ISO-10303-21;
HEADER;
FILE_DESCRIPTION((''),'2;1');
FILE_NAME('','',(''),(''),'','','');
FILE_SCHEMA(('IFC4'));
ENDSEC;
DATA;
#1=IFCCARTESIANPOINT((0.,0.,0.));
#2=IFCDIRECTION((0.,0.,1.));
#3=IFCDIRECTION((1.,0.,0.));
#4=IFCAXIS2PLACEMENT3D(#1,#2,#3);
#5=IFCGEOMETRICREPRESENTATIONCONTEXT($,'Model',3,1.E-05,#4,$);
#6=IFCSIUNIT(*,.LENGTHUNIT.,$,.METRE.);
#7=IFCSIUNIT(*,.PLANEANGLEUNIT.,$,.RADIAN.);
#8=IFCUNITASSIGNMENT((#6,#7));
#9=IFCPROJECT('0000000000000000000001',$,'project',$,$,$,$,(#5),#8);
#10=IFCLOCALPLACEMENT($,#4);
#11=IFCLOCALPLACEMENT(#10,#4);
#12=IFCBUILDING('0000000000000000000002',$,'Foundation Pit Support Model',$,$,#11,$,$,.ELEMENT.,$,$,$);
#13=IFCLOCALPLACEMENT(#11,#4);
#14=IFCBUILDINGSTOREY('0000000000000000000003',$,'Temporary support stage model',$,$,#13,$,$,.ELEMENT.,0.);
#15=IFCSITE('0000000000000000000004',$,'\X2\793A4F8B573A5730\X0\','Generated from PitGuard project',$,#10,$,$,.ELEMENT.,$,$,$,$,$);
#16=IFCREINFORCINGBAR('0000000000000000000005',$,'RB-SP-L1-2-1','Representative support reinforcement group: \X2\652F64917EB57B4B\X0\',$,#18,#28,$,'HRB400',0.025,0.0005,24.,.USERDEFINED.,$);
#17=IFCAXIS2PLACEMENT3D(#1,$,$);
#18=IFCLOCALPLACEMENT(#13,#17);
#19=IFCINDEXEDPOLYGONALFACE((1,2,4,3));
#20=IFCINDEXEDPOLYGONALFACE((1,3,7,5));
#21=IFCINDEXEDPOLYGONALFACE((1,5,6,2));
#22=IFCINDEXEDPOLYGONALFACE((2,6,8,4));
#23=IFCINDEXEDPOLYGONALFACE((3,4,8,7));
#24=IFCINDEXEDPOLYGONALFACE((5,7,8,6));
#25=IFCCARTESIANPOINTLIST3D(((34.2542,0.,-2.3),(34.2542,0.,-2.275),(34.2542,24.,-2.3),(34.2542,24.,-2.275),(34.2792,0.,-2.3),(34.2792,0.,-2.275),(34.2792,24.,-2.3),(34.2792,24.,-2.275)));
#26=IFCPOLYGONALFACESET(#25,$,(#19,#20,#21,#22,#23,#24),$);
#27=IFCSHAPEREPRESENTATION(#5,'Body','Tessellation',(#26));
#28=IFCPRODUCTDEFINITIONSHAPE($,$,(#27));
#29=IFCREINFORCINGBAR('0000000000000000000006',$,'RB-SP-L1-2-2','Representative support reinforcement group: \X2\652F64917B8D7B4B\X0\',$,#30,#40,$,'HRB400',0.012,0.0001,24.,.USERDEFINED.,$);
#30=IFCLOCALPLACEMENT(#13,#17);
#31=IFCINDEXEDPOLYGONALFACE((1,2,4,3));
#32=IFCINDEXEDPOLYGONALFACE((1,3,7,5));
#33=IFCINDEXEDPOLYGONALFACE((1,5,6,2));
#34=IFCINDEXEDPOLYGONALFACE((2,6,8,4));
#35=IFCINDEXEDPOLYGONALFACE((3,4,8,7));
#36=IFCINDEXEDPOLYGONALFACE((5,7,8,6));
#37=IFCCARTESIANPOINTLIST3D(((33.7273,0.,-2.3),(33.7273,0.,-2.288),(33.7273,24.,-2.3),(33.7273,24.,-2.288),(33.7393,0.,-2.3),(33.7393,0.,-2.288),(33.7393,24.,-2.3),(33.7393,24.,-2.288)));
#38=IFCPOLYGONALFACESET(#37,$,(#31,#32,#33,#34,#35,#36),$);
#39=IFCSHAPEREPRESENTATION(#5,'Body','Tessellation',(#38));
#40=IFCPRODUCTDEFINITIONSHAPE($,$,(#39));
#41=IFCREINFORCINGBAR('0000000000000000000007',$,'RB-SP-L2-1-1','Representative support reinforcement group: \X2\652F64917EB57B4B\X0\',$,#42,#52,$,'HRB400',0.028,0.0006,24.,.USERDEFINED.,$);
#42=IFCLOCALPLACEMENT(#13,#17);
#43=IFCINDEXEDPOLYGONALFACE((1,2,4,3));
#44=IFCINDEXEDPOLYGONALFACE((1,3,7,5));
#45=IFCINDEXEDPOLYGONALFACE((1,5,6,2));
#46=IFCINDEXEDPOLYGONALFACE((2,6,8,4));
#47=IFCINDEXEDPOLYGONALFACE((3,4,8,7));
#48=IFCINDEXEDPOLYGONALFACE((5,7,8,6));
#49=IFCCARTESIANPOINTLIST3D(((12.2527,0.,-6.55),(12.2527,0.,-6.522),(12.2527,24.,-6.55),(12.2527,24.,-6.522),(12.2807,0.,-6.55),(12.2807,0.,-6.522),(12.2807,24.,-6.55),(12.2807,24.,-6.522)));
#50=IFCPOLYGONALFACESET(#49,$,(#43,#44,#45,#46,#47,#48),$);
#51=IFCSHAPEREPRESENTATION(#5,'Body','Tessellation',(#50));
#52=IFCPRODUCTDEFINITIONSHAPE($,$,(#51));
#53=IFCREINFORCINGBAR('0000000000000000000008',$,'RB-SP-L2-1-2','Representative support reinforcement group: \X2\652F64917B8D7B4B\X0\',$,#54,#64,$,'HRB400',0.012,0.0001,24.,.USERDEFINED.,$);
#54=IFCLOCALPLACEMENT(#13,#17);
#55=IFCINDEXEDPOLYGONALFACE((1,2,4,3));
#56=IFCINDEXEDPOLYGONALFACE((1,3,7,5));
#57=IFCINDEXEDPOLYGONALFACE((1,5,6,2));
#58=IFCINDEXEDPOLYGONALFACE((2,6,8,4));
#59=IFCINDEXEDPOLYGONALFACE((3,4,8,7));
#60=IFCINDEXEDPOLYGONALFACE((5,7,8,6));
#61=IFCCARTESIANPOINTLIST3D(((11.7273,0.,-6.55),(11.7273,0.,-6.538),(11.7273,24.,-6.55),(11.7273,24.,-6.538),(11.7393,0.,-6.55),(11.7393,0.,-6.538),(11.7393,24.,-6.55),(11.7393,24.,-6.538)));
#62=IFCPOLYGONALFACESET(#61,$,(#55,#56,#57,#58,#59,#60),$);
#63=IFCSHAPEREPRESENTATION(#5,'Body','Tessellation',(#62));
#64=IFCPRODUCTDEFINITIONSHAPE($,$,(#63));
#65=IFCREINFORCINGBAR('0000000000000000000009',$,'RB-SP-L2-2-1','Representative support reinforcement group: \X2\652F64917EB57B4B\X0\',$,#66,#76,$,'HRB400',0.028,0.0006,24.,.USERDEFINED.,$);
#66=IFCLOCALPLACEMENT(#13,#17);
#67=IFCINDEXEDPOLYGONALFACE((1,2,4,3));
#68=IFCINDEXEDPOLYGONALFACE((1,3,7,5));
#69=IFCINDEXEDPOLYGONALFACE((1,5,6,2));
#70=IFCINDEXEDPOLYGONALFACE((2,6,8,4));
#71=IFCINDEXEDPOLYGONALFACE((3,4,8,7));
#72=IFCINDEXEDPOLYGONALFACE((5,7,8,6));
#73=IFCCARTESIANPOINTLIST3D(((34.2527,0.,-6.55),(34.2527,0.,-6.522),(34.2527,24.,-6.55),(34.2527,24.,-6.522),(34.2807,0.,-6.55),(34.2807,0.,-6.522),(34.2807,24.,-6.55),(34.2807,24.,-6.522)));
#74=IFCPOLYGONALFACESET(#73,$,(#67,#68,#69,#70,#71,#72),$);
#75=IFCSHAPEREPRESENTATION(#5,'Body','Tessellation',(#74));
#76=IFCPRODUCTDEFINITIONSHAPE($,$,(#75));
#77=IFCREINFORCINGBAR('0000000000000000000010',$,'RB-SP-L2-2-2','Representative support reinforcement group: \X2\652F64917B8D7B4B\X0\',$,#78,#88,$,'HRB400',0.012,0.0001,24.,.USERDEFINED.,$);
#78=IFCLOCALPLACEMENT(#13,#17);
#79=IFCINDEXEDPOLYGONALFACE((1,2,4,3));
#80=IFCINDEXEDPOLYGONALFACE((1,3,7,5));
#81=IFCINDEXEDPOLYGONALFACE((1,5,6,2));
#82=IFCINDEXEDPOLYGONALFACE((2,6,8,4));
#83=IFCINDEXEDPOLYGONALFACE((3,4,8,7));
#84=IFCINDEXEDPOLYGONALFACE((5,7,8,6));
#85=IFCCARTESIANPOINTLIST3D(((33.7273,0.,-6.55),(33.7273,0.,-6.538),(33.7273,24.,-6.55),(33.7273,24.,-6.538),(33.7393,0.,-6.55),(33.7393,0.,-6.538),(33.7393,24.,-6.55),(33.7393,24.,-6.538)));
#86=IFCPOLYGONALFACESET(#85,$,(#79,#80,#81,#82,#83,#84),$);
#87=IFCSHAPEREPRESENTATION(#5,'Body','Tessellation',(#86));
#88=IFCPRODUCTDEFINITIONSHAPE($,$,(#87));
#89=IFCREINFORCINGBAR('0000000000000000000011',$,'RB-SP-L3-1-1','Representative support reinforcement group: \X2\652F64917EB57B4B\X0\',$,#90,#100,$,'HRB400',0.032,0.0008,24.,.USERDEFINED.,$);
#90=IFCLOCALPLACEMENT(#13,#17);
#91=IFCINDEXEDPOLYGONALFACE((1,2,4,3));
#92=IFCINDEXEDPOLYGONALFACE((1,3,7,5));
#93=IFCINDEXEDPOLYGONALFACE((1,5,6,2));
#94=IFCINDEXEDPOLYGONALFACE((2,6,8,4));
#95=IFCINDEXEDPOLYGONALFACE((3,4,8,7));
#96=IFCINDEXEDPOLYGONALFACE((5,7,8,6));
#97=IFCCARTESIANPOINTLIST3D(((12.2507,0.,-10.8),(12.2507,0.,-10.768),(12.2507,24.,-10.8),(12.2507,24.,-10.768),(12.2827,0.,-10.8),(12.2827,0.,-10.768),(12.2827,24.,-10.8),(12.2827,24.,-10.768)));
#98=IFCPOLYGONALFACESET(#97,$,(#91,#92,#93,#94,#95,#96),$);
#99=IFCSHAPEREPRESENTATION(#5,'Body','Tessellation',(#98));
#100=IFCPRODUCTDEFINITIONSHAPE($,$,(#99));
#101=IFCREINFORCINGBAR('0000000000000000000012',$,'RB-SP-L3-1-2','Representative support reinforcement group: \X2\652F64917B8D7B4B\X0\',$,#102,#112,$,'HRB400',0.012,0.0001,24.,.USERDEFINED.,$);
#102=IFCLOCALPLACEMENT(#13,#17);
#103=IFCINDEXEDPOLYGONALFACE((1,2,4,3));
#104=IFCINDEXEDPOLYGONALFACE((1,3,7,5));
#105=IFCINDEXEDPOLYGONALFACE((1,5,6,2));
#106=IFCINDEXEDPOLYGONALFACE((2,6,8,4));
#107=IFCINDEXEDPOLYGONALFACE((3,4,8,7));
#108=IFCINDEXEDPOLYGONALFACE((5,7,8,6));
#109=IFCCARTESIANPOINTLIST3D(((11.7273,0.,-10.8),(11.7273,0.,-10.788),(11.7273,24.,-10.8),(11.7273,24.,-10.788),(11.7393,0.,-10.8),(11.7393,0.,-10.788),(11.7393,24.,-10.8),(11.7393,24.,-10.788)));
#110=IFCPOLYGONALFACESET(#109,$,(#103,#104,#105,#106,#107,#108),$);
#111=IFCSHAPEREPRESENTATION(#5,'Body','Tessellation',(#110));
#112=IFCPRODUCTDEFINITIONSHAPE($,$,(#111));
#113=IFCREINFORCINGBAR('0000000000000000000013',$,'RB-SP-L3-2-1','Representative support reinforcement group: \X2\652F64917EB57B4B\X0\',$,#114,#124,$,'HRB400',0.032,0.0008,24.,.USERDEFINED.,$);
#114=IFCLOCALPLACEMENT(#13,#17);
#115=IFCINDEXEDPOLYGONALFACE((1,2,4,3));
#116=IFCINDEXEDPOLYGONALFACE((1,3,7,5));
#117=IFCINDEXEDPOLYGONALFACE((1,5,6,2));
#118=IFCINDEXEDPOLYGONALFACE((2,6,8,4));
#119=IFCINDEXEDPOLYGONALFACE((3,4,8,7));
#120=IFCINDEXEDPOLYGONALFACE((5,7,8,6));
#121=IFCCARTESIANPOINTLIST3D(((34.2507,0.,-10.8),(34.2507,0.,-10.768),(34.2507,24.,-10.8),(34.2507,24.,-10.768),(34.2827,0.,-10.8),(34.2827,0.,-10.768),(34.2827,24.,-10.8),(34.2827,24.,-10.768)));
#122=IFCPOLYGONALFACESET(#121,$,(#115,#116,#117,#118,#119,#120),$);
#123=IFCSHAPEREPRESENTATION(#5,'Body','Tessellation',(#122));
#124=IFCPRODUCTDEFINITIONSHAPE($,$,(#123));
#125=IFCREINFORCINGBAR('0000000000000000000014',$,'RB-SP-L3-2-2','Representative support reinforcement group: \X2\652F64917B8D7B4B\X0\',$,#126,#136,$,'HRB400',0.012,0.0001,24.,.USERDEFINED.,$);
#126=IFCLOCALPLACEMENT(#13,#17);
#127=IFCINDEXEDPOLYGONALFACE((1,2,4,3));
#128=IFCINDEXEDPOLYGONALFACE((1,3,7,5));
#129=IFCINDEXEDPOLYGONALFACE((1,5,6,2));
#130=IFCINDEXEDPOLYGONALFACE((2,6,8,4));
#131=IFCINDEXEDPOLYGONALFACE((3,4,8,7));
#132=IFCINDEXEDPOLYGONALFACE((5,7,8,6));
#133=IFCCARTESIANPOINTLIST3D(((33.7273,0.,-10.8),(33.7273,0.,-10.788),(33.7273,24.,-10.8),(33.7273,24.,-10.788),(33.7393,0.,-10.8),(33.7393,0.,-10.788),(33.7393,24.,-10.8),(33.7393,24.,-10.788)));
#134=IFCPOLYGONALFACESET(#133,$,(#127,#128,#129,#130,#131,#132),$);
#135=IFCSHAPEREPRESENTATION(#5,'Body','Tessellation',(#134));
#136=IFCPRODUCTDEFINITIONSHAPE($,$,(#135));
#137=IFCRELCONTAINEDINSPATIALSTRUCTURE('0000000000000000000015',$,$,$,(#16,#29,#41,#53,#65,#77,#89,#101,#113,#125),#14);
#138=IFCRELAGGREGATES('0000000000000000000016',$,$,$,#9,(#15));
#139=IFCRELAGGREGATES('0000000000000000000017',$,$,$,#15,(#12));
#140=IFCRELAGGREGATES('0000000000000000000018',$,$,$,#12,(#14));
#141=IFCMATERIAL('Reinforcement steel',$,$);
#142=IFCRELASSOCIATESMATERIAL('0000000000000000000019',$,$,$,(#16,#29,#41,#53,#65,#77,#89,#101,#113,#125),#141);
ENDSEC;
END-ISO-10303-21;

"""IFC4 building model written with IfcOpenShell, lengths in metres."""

from ifc_helpers import new_model, si_unit, frame, origin_with_axes, origin_2d, place, context, project, spatial, rectangle, extrude, material, element, save


model = new_model("IFC4")

# Units and contexts
model_context = context("Model", 3, precision=1e-05, world=origin_with_axes())
ifc_project = project(units=[si_unit("LENGTHUNIT", "METRE"), si_unit("PLANEANGLEUNIT", "RADIAN")], contexts=[model_context])

# Site, building, storey
site_placement = place(None, origin_with_axes())
site = spatial("IfcSite", under=ifc_project, at=site_placement, Name="示例场地", Description="Generated from PitGuard project", CompositionType="ELEMENT")
building_placement = place(site_placement, origin_with_axes())
building = spatial("IfcBuilding", under=site, at=building_placement, Name="Foundation Pit Support Model", CompositionType="ELEMENT")
storey_placement = place(building_placement, origin_with_axes())
storey = spatial("IfcBuildingStorey", under=building, at=storey_placement, Name="Temporary support stage model", CompositionType="ELEMENT", Elevation=0.0)

# Reinforcing bars
ifc_material_1 = material(Name="Reinforcement steel")
reinforcing_bar_1_placement = place(storey_placement, frame((34.2667, 12.0, -2.3), z_axis=(0.0, 0.0, 1.0), x_axis=(0.0, 1.0, 0.0)))
element("IfcReinforcingBar", 1, at=reinforcing_bar_1_placement, inside=storey, material=ifc_material_1, Name="RB-SP-L1-2-1", Description="Representative support reinforcement group: 支撑纵筋", SteelGrade="HRB400", BarLength=24.0, CrossSectionArea=0.0005, NominalDiameter=0.025, PredefinedType="USERDEFINED", context=model_context, shape_type="SweptSolid", body=[
    extrude(rectangle(XDim=24.0, YDim=0.025, at=origin_2d()), origin_with_axes(), (0.0, 0.0, 1.0), 0.025),
])
reinforcing_bar_2_placement = place(storey_placement, frame((33.7333, 12.0, -2.3), z_axis=(0.0, 0.0, 1.0), x_axis=(0.0, 1.0, 0.0)))
element("IfcReinforcingBar", 2, at=reinforcing_bar_2_placement, inside=storey, material=ifc_material_1, Name="RB-SP-L1-2-2", Description="Representative support reinforcement group: 支撑箍筋", SteelGrade="HRB400", BarLength=24.0, CrossSectionArea=0.0001, NominalDiameter=0.012, PredefinedType="USERDEFINED", context=model_context, shape_type="SweptSolid", body=[
    extrude(rectangle(XDim=24.0, YDim=0.012, at=origin_2d()), origin_with_axes(), (0.0, 0.0, 1.0), 0.012),
])
reinforcing_bar_3_placement = place(storey_placement, frame((12.2667, 12.0, -6.55), z_axis=(0.0, 0.0, 1.0), x_axis=(0.0, 1.0, 0.0)))
element("IfcReinforcingBar", 3, at=reinforcing_bar_3_placement, inside=storey, material=ifc_material_1, Name="RB-SP-L2-1-1", Description="Representative support reinforcement group: 支撑纵筋", SteelGrade="HRB400", BarLength=24.0, CrossSectionArea=0.0006, NominalDiameter=0.028, PredefinedType="USERDEFINED", context=model_context, shape_type="SweptSolid", body=[
    extrude(rectangle(XDim=24.0, YDim=0.028, at=origin_2d()), origin_with_axes(), (0.0, 0.0, 1.0), 0.028),
])
reinforcing_bar_4_placement = place(storey_placement, frame((11.7333, 12.0, -6.55), z_axis=(0.0, 0.0, 1.0), x_axis=(0.0, 1.0, 0.0)))
element("IfcReinforcingBar", 4, at=reinforcing_bar_4_placement, inside=storey, material=ifc_material_1, Name="RB-SP-L2-1-2", Description="Representative support reinforcement group: 支撑箍筋", SteelGrade="HRB400", BarLength=24.0, CrossSectionArea=0.0001, NominalDiameter=0.012, PredefinedType="USERDEFINED", context=model_context, shape_type="SweptSolid", body=[
    extrude(rectangle(XDim=24.0, YDim=0.012, at=origin_2d()), origin_with_axes(), (0.0, 0.0, 1.0), 0.012),
])
reinforcing_bar_5_placement = place(storey_placement, frame((34.2667, 12.0, -6.55), z_axis=(0.0, 0.0, 1.0), x_axis=(0.0, 1.0, 0.0)))
element("IfcReinforcingBar", 5, at=reinforcing_bar_5_placement, inside=storey, material=ifc_material_1, Name="RB-SP-L2-2-1", Description="Representative support reinforcement group: 支撑纵筋", SteelGrade="HRB400", BarLength=24.0, CrossSectionArea=0.0006, NominalDiameter=0.028, PredefinedType="USERDEFINED", context=model_context, shape_type="SweptSolid", body=[
    extrude(rectangle(XDim=24.0, YDim=0.028, at=origin_2d()), origin_with_axes(), (0.0, 0.0, 1.0), 0.028),
])
reinforcing_bar_6_placement = place(storey_placement, frame((33.7333, 12.0, -6.55), z_axis=(0.0, 0.0, 1.0), x_axis=(0.0, 1.0, 0.0)))
element("IfcReinforcingBar", 6, at=reinforcing_bar_6_placement, inside=storey, material=ifc_material_1, Name="RB-SP-L2-2-2", Description="Representative support reinforcement group: 支撑箍筋", SteelGrade="HRB400", BarLength=24.0, CrossSectionArea=0.0001, NominalDiameter=0.012, PredefinedType="USERDEFINED", context=model_context, shape_type="SweptSolid", body=[
    extrude(rectangle(XDim=24.0, YDim=0.012, at=origin_2d()), origin_with_axes(), (0.0, 0.0, 1.0), 0.012),
])
reinforcing_bar_7_placement = place(storey_placement, frame((12.2667, 12.0, -10.8), z_axis=(0.0, 0.0, 1.0), x_axis=(0.0, 1.0, 0.0)))
element("IfcReinforcingBar", 7, at=reinforcing_bar_7_placement, inside=storey, material=ifc_material_1, Name="RB-SP-L3-1-1", Description="Representative support reinforcement group: 支撑纵筋", SteelGrade="HRB400", BarLength=24.0, CrossSectionArea=0.0008, NominalDiameter=0.032, PredefinedType="USERDEFINED", context=model_context, shape_type="SweptSolid", body=[
    extrude(rectangle(XDim=24.0, YDim=0.032, at=origin_2d()), origin_with_axes(), (0.0, 0.0, 1.0), 0.032),
])
reinforcing_bar_8_placement = place(storey_placement, frame((11.7333, 12.0, -10.8), z_axis=(0.0, 0.0, 1.0), x_axis=(0.0, 1.0, 0.0)))
element("IfcReinforcingBar", 8, at=reinforcing_bar_8_placement, inside=storey, material=ifc_material_1, Name="RB-SP-L3-1-2", Description="Representative support reinforcement group: 支撑箍筋", SteelGrade="HRB400", BarLength=24.0, CrossSectionArea=0.0001, NominalDiameter=0.012, PredefinedType="USERDEFINED", context=model_context, shape_type="SweptSolid", body=[
    extrude(rectangle(XDim=24.0, YDim=0.012, at=origin_2d()), origin_with_axes(), (0.0, 0.0, 1.0), 0.012),
])
reinforcing_bar_9_placement = place(storey_placement, frame((34.2667, 12.0, -10.8), z_axis=(0.0, 0.0, 1.0), x_axis=(0.0, 1.0, 0.0)))
element("IfcReinforcingBar", 9, at=reinforcing_bar_9_placement, inside=storey, material=ifc_material_1, Name="RB-SP-L3-2-1", Description="Representative support reinforcement group: 支撑纵筋", SteelGrade="HRB400", BarLength=24.0, CrossSectionArea=0.0008, NominalDiameter=0.032, PredefinedType="USERDEFINED", context=model_context, shape_type="SweptSolid", body=[
    extrude(rectangle(XDim=24.0, YDim=0.032, at=origin_2d()), origin_with_axes(), (0.0, 0.0, 1.0), 0.032),
])
reinforcing_bar_10_placement = place(storey_placement, frame((33.7333, 12.0, -10.8), z_axis=(0.0, 0.0, 1.0), x_axis=(0.0, 1.0, 0.0)))
element("IfcReinforcingBar", 10, at=reinforcing_bar_10_placement, inside=storey, material=ifc_material_1, Name="RB-SP-L3-2-2", Description="Representative support reinforcement group: 支撑箍筋", SteelGrade="HRB400", BarLength=24.0, CrossSectionArea=0.0001, NominalDiameter=0.012, PredefinedType="USERDEFINED", context=model_context, shape_type="SweptSolid", body=[
    extrude(rectangle(XDim=24.0, YDim=0.012, at=origin_2d()), origin_with_axes(), (0.0, 0.0, 1.0), 0.012),
])

save(model, "model.ifc")
